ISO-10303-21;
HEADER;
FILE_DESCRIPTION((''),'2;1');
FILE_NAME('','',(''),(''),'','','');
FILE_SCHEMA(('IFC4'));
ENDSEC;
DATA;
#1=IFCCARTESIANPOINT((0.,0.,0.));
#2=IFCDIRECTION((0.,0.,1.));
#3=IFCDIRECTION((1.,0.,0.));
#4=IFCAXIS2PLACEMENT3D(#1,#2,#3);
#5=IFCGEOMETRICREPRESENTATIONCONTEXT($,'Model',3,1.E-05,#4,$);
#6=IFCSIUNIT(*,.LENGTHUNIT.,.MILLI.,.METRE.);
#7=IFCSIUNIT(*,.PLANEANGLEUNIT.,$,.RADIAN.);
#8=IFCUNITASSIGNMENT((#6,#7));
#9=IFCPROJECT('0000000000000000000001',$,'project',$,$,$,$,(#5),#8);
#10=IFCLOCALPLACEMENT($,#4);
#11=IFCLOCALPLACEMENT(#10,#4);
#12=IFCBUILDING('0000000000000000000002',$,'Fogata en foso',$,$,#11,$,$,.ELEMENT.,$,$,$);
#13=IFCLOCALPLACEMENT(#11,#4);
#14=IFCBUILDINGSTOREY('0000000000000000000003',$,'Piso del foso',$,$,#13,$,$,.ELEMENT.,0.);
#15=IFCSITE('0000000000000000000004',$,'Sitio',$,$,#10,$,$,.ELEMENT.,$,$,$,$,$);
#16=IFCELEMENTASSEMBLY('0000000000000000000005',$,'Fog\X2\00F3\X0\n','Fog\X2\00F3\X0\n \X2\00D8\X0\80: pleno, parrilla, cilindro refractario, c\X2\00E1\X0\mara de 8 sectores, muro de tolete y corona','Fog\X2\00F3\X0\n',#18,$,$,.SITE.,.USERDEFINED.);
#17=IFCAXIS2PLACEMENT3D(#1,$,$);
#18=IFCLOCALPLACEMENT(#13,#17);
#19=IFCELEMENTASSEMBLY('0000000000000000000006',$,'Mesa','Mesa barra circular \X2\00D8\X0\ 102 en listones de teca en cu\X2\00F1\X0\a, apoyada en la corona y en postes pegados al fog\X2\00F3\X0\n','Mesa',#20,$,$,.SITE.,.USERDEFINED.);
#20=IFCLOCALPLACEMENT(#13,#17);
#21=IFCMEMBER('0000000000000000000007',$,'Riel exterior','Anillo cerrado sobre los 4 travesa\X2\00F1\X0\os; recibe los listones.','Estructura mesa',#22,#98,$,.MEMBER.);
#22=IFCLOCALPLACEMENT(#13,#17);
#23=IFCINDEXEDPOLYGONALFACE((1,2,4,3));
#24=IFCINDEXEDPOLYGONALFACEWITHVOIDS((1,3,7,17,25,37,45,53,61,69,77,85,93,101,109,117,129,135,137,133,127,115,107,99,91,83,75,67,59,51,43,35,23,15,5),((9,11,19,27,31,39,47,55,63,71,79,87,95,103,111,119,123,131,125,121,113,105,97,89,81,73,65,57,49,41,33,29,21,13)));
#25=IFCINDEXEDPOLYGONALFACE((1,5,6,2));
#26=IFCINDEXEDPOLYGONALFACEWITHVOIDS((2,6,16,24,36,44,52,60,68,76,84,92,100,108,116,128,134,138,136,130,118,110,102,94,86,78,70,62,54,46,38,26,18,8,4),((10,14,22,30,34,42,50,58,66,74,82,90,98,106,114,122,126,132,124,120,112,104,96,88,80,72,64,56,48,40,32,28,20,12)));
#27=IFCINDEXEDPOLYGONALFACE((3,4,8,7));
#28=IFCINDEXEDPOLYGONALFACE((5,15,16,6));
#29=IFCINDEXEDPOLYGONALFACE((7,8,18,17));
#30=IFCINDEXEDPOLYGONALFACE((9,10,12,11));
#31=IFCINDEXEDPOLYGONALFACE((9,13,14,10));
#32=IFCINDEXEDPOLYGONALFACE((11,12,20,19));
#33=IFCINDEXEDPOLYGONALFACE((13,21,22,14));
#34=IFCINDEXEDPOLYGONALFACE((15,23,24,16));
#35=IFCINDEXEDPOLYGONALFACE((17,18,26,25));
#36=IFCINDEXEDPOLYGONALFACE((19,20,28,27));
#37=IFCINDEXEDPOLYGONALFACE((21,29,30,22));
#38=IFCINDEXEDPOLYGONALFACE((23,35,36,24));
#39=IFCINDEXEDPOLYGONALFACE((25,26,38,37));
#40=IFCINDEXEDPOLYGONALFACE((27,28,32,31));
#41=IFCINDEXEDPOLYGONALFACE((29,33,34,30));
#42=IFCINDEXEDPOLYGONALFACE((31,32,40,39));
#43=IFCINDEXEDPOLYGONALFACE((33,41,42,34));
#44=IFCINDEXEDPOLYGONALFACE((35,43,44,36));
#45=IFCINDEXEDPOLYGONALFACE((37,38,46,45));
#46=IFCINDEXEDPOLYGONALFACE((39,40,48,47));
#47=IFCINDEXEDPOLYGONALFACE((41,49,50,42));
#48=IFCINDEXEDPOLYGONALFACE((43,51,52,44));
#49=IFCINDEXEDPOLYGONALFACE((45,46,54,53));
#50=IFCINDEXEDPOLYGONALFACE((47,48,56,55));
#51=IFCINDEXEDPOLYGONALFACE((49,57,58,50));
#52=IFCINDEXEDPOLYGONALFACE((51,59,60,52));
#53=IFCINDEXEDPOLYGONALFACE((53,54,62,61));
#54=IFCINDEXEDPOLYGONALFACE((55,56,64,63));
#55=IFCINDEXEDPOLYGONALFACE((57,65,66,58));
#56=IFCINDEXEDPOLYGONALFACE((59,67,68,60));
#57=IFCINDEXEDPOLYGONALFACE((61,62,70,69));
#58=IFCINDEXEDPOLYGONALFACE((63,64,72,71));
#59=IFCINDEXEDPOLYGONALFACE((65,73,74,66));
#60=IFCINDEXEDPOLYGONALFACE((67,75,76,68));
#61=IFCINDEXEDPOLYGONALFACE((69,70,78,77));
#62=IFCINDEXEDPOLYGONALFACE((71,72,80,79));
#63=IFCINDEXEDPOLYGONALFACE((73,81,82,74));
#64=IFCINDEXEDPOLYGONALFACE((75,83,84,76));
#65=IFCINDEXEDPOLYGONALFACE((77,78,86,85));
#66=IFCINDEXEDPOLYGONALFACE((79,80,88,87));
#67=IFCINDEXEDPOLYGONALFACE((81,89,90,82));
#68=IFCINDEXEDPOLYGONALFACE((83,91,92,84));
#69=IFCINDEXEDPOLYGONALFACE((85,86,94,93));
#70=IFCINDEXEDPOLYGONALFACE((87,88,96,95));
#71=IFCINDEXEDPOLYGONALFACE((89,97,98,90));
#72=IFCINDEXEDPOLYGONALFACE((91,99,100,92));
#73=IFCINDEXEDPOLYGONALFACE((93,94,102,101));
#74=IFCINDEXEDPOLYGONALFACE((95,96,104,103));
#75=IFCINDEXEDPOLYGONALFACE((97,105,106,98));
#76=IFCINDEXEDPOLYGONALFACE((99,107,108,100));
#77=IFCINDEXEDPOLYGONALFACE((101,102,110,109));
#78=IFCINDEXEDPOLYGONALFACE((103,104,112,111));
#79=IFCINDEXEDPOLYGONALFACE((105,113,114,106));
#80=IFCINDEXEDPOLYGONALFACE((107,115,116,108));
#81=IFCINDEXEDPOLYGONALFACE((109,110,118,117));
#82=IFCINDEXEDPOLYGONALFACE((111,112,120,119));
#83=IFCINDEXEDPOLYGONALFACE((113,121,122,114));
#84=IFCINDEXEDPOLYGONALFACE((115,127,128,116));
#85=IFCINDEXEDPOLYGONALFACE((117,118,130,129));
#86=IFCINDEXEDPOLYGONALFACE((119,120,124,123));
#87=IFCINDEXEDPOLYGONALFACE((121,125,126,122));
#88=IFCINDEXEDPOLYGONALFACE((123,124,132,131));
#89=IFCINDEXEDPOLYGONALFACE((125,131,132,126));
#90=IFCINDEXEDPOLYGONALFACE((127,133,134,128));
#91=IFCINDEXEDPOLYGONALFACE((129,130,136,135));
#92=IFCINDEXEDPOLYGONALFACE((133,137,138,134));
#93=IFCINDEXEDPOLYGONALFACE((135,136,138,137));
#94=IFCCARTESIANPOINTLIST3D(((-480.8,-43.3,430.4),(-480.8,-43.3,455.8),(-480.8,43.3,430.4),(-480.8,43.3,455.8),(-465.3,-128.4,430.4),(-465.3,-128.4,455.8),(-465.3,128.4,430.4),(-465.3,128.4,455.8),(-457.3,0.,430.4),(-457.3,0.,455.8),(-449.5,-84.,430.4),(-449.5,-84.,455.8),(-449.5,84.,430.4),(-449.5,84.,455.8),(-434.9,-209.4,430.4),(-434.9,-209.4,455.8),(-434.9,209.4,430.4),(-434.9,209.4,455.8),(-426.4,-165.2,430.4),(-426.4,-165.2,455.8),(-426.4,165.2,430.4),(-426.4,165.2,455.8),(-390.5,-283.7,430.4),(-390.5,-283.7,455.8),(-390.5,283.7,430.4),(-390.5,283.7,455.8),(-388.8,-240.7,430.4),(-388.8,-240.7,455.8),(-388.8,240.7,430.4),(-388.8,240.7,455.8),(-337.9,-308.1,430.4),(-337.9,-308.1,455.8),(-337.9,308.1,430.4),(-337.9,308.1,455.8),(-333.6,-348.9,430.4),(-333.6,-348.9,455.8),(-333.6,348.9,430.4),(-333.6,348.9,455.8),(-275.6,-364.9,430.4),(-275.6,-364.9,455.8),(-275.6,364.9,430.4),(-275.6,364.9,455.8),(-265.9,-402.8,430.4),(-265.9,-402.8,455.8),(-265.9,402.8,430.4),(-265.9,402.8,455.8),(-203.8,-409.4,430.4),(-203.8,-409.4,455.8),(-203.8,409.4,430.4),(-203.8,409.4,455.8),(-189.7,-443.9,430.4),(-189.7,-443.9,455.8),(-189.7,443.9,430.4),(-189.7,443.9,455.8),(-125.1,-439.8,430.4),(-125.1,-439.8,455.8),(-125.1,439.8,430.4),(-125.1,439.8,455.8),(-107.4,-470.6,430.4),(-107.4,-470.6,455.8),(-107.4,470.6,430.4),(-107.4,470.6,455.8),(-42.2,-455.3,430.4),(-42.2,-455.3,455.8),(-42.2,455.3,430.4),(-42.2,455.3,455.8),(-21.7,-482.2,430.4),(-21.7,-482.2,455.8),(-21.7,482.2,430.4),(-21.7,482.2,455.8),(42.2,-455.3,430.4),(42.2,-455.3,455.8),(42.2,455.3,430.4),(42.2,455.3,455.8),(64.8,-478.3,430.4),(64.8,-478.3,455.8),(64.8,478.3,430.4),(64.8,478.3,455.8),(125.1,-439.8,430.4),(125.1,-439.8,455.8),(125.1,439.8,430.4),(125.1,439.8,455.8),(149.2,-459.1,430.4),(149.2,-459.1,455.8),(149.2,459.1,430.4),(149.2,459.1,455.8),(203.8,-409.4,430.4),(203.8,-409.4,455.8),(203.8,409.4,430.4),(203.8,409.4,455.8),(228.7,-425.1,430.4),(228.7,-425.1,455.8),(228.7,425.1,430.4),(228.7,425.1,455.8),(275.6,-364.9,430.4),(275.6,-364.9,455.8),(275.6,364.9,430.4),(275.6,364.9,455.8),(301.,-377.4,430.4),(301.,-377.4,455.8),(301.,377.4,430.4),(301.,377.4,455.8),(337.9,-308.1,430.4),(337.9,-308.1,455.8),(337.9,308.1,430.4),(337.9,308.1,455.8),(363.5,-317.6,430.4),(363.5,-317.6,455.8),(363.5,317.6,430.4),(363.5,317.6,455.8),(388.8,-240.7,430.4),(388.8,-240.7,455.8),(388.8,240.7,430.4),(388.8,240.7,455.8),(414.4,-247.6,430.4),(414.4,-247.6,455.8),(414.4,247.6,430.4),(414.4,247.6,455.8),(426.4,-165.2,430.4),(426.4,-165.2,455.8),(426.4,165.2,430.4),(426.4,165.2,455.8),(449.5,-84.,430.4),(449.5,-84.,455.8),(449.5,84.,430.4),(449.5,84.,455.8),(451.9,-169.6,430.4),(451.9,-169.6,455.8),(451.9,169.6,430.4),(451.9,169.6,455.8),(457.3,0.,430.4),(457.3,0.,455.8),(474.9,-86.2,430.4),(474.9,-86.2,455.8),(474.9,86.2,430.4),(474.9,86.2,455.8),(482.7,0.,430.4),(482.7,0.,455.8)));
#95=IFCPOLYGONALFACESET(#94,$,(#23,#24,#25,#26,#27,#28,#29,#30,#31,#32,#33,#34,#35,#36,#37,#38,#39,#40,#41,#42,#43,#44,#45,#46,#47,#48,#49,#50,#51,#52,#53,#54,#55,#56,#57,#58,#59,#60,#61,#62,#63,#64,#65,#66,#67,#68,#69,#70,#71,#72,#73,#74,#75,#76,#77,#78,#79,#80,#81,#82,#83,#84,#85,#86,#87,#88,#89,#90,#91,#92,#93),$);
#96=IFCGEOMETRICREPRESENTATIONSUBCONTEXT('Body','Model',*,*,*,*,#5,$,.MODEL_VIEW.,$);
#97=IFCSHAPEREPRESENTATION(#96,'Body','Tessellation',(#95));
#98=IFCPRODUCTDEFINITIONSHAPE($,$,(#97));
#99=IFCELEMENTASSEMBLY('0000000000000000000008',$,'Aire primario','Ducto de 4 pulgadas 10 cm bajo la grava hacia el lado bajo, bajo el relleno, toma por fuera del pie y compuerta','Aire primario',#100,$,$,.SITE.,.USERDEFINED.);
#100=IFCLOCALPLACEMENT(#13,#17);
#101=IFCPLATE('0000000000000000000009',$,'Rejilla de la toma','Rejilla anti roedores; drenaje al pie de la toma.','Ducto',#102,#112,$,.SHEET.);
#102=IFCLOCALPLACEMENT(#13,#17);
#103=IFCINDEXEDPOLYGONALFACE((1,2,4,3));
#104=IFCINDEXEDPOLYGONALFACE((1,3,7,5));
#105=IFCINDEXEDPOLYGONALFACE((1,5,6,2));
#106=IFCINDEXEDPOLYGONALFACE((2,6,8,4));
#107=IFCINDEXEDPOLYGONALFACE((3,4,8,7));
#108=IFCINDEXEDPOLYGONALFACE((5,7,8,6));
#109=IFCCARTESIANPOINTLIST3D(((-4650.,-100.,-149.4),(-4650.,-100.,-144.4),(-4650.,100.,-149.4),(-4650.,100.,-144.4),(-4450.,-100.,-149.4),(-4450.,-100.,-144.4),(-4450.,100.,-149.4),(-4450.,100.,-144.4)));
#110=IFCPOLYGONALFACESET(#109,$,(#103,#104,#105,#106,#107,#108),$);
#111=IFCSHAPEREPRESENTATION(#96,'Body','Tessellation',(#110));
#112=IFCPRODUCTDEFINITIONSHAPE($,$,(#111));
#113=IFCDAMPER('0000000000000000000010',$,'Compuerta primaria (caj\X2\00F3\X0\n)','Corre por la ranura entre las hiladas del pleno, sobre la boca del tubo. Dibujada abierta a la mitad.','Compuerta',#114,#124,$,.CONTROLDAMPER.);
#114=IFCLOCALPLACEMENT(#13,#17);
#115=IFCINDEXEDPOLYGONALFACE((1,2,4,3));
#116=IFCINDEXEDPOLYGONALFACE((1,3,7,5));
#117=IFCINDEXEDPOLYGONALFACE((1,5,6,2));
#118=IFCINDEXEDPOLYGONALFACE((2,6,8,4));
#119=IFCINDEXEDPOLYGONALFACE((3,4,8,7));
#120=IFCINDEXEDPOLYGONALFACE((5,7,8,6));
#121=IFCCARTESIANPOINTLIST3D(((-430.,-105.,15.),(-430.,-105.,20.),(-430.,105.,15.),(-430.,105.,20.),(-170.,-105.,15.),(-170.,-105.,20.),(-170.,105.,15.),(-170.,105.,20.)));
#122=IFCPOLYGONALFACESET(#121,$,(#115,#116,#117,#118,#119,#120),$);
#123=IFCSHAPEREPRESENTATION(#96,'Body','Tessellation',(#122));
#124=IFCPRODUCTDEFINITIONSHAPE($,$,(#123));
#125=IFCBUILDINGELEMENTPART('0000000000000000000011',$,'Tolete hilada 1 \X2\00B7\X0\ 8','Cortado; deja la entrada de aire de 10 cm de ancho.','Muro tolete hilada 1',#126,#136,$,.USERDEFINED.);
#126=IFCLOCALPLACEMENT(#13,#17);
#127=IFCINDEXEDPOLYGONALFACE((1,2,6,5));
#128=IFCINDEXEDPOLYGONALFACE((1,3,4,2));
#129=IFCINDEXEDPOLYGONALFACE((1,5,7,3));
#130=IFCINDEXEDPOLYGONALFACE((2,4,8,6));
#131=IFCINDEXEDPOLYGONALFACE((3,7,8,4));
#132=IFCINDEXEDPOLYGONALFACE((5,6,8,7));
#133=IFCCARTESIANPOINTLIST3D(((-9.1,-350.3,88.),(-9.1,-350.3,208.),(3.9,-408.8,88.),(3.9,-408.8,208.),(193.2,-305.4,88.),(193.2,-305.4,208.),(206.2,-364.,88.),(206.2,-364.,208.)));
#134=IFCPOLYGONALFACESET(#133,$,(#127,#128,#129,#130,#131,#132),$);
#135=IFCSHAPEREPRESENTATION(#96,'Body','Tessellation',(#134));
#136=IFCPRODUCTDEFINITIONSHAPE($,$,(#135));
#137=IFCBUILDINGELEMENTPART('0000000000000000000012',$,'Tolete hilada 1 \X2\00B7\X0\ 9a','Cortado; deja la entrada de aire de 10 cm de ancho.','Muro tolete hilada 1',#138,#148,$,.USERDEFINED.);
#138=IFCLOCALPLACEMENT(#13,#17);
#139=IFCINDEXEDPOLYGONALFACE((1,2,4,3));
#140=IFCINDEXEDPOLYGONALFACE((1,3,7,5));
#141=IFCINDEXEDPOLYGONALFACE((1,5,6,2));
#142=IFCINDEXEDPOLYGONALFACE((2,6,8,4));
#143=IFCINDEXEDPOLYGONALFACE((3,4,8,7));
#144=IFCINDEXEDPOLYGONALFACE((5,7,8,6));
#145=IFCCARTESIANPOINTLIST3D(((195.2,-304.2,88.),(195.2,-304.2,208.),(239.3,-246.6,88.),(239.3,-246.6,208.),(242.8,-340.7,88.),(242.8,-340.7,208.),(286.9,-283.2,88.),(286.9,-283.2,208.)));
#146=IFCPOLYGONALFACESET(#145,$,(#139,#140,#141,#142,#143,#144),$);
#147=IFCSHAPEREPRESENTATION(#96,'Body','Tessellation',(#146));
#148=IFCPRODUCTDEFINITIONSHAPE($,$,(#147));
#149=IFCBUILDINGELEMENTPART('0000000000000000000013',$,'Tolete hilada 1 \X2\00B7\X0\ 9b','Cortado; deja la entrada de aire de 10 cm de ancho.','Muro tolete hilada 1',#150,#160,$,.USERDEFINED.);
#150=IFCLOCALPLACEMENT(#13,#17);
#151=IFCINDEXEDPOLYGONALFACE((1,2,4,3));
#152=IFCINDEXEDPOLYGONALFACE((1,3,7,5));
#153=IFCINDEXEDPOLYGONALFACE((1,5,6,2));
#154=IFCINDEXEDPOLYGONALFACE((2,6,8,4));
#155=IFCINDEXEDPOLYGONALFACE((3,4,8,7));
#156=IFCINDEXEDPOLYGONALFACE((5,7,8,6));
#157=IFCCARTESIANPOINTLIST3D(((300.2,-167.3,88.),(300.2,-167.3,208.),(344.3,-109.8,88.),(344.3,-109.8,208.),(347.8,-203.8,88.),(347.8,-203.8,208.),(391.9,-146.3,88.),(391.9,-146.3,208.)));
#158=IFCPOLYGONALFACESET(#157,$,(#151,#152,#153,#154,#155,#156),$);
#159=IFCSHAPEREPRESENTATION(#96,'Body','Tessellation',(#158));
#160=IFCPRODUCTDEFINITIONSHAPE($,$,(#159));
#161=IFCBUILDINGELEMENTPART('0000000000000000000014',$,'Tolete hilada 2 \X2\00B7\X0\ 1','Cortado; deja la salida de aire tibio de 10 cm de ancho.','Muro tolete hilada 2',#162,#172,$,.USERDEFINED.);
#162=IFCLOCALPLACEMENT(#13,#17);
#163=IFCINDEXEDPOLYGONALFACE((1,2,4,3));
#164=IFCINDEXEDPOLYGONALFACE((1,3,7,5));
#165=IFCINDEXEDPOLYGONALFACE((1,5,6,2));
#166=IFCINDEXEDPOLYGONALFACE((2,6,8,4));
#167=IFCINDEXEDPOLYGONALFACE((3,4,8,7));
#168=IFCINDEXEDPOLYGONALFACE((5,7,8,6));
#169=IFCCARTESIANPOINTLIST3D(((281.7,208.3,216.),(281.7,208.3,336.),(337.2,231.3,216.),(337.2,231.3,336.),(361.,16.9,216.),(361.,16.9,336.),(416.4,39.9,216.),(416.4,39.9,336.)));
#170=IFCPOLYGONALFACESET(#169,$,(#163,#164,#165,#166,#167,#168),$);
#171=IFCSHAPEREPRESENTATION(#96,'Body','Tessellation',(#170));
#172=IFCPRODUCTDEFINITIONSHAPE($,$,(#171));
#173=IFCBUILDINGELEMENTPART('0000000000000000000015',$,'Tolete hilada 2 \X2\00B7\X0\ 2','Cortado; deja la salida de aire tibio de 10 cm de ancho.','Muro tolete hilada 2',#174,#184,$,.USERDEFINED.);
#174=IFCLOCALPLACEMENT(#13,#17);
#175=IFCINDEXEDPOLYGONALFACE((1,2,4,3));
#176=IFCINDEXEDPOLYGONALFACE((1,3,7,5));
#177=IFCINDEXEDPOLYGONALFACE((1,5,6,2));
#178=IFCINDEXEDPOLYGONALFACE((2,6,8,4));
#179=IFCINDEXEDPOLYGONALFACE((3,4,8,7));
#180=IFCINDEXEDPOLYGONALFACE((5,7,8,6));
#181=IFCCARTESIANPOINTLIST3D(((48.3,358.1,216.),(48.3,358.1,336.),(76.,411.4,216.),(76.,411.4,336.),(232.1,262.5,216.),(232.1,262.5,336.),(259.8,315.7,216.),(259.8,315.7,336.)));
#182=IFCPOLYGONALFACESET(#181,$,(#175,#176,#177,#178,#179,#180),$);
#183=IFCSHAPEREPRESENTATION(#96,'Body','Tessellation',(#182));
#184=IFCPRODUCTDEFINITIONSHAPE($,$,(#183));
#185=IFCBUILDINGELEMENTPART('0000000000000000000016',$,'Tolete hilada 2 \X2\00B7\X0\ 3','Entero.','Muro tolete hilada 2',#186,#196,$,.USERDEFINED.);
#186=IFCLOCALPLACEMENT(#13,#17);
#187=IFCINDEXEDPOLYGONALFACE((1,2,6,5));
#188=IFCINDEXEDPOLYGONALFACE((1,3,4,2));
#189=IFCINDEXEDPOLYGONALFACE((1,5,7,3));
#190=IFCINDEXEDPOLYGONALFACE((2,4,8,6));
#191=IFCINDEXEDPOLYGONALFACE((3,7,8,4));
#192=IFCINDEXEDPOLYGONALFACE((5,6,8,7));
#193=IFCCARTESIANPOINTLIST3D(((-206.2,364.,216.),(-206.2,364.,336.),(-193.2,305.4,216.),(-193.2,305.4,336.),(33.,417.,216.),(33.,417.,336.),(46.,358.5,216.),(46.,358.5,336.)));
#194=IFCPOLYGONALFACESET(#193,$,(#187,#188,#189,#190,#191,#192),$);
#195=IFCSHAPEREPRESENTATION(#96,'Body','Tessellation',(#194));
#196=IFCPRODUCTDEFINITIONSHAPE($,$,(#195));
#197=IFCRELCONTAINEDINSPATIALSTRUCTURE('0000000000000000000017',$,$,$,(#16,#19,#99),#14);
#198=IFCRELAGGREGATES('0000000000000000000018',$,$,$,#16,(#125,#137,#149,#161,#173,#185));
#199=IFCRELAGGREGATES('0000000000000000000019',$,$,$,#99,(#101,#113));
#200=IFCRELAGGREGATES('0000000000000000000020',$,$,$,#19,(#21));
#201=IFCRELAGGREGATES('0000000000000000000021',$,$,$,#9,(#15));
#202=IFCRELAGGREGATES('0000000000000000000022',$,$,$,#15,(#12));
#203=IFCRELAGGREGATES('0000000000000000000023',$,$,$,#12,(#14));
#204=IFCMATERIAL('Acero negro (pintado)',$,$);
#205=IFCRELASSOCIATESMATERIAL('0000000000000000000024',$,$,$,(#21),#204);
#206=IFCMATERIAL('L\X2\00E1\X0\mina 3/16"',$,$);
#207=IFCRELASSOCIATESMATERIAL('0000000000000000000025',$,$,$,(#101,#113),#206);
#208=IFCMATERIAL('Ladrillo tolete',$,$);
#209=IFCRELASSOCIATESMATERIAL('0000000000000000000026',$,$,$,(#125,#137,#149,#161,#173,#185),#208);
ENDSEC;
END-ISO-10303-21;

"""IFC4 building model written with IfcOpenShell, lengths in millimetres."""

from ifc_helpers import new_model, si_unit, frame, origin_with_axes, origin_2d, place, context, subcontext, project, spatial, polyline, hollow_circle, outline, extrude, material, element, aggregate, save


model = new_model("IFC4")

# Units and contexts
model_context = context("Model", 3, precision=1e-05, world=origin_with_axes())
body_context = subcontext(model_context, "Body", "Model", "MODEL_VIEW")
ifc_project = project(units=[si_unit("LENGTHUNIT", "METRE", prefix="MILLI"), si_unit("PLANEANGLEUNIT", "RADIAN")], contexts=[model_context])

# Site, building, storey
site_placement = place(None, origin_with_axes())
site = spatial("IfcSite", under=ifc_project, at=site_placement, Name="Sitio", CompositionType="ELEMENT")
building_placement = place(site_placement, origin_with_axes())
building = spatial("IfcBuilding", under=site, at=building_placement, Name="Fogata en foso", CompositionType="ELEMENT")
storey_placement = place(building_placement, origin_with_axes())
storey = spatial("IfcBuildingStorey", under=building, at=storey_placement, Name="Piso del foso", CompositionType="ELEMENT", Elevation=0.0)

# Element assembly
assembly_1_placement = place(storey_placement, origin_with_axes())
assembly_1 = element("IfcElementAssembly", 1, at=assembly_1_placement, inside=storey, Name="Fogón", Description="Fogón Ø80: pleno, parrilla, cilindro refractario, cámara de 8 sectores, muro de tolete y corona", ObjectType="Fogón", AssemblyPlace="SITE", PredefinedType="USERDEFINED")

# Element assembly, member
assembly_2_placement = place(storey_placement, origin_with_axes())
assembly_2 = element("IfcElementAssembly", 2, at=assembly_2_placement, inside=storey, Name="Mesa", Description="Mesa barra circular Ø 102 en listones de teca en cuña, apoyada en la corona y en postes pegados al fogón", ObjectType="Mesa", AssemblyPlace="SITE", PredefinedType="USERDEFINED")
ifc_material_1 = material(Name="Acero negro (pintado)")
member_1_placement = place(storey_placement, frame((0.0, 0.0, 430.4), z_axis=(0.0, 0.0, 1.0), x_axis=(1.0, 0.0, 0.0)))
member_1 = element("IfcMember", 3, at=member_1_placement, material=ifc_material_1, Name="Riel exterior", Description="Anillo cerrado sobre los 4 travesaños; recibe los listones.", ObjectType="Estructura mesa", PredefinedType="MEMBER", context=body_context, shape_type="SweptSolid", body=[
    extrude(hollow_circle(Radius=482.7, WallThickness=25.4, at=origin_2d()), origin_with_axes(), (0.0, 0.0, 1.0), 25.4),
])

# Element assembly, plate, damper
assembly_3_placement = place(storey_placement, origin_with_axes())
assembly_3 = element("IfcElementAssembly", 4, at=assembly_3_placement, inside=storey, Name="Aire primario", Description="Ducto de 4 pulgadas 10 cm bajo la grava hacia el lado bajo, bajo el relleno, toma por fuera del pie y compuerta", ObjectType="Aire primario", AssemblyPlace="SITE", PredefinedType="USERDEFINED")
ifc_material_2 = material(Name="Lámina 3/16\"")
plate_placement = place(storey_placement, frame((0.0, 0.0, -149.4), z_axis=(0.0, 0.0, 1.0), x_axis=(1.0, 0.0, 0.0)))
plate = element("IfcPlate", 5, at=plate_placement, material=ifc_material_2, Name="Rejilla de la toma", Description="Rejilla anti roedores; drenaje al pie de la toma.", ObjectType="Ducto", PredefinedType="SHEET", context=body_context, shape_type="SweptSolid", body=[
    extrude(outline(polyline([(-4650.0, -100.0), (-4450.0, -100.0), (-4450.0, 100.0), (-4650.0, 100.0), (-4650.0, -100.0)])), origin_with_axes(), (0.0, 0.0, 1.0), 5.0),
])
damper_placement = place(storey_placement, frame((0.0, 0.0, 15.0), z_axis=(0.0, 0.0, 1.0), x_axis=(1.0, 0.0, 0.0)))
damper = element("IfcDamper", 6, at=damper_placement, material=ifc_material_2, Name="Compuerta primaria (cajón)", Description="Corre por la ranura entre las hiladas del pleno, sobre la boca del tubo. Dibujada abierta a la mitad.", ObjectType="Compuerta", PredefinedType="CONTROLDAMPER", context=body_context, shape_type="SweptSolid", body=[
    extrude(outline(polyline([(-430.0, -105.0), (-170.0, -105.0), (-170.0, 105.0), (-430.0, 105.0), (-430.0, -105.0)])), origin_with_axes(), (0.0, 0.0, 1.0), 5.0),
])

# Building element parts
ifc_material_3 = material(Name="Ladrillo tolete")
building_element_part_1_placement = place(storey_placement, frame((0.0, 0.0, 88.0), z_axis=(0.0, 0.0, 1.0), x_axis=(1.0, 0.0, 0.0)))
building_element_part_1 = element("IfcBuildingElementPart", 7, at=building_element_part_1_placement, material=ifc_material_3, Name="Tolete hilada 1 · 8", Description="Cortado; deja la entrada de aire de 10 cm de ancho.", ObjectType="Muro tolete hilada 1", PredefinedType="USERDEFINED", context=body_context, shape_type="SweptSolid", body=[
    extrude(outline(polyline([(3.9, -408.8), (206.2, -364.0), (193.2, -305.4), (-9.1, -350.3), (3.9, -408.8)])), origin_with_axes(), (0.0, 0.0, 1.0), 120.0),
])
building_element_part_2_placement = place(storey_placement, frame((0.0, 0.0, 88.0), z_axis=(0.0, 0.0, 1.0), x_axis=(1.0, 0.0, 0.0)))
building_element_part_2 = element("IfcBuildingElementPart", 8, at=building_element_part_2_placement, material=ifc_material_3, Name="Tolete hilada 1 · 9a", Description="Cortado; deja la entrada de aire de 10 cm de ancho.", ObjectType="Muro tolete hilada 1", PredefinedType="USERDEFINED", context=body_context, shape_type="SweptSolid", body=[
    extrude(outline(polyline([(242.8, -340.7), (286.9, -283.2), (239.3, -246.6), (195.2, -304.2), (242.8, -340.7)])), origin_with_axes(), (0.0, 0.0, 1.0), 120.0),
])
building_element_part_3_placement = place(storey_placement, frame((0.0, 0.0, 88.0), z_axis=(0.0, 0.0, 1.0), x_axis=(1.0, 0.0, 0.0)))
building_element_part_3 = element("IfcBuildingElementPart", 9, at=building_element_part_3_placement, material=ifc_material_3, Name="Tolete hilada 1 · 9b", Description="Cortado; deja la entrada de aire de 10 cm de ancho.", ObjectType="Muro tolete hilada 1", PredefinedType="USERDEFINED", context=body_context, shape_type="SweptSolid", body=[
    extrude(outline(polyline([(347.8, -203.8), (391.9, -146.3), (344.3, -109.8), (300.2, -167.3), (347.8, -203.8)])), origin_with_axes(), (0.0, 0.0, 1.0), 120.0),
])
building_element_part_4_placement = place(storey_placement, frame((0.0, 0.0, 216.0), z_axis=(0.0, 0.0, 1.0), x_axis=(1.0, 0.0, 0.0)))
building_element_part_4 = element("IfcBuildingElementPart", 10, at=building_element_part_4_placement, material=ifc_material_3, Name="Tolete hilada 2 · 1", Description="Cortado; deja la salida de aire tibio de 10 cm de ancho.", ObjectType="Muro tolete hilada 2", PredefinedType="USERDEFINED", context=body_context, shape_type="SweptSolid", body=[
    extrude(outline(polyline([(416.4, 39.9), (337.1, 231.3), (281.7, 208.3), (361.0, 16.9), (416.4, 39.9)])), origin_with_axes(), (0.0, 0.0, 1.0), 120.0),
])
building_element_part_5_placement = place(storey_placement, frame((0.0, 0.0, 216.0), z_axis=(0.0, 0.0, 1.0), x_axis=(1.0, 0.0, 0.0)))
building_element_part_5 = element("IfcBuildingElementPart", 11, at=building_element_part_5_placement, material=ifc_material_3, Name="Tolete hilada 2 · 2", Description="Cortado; deja la salida de aire tibio de 10 cm de ancho.", ObjectType="Muro tolete hilada 2", PredefinedType="USERDEFINED", context=body_context, shape_type="SweptSolid", body=[
    extrude(outline(polyline([(259.8, 315.7), (76.0, 411.4), (48.3, 358.1), (232.1, 262.5), (259.8, 315.7)])), origin_with_axes(), (0.0, 0.0, 1.0), 120.0),
])
building_element_part_6_placement = place(storey_placement, frame((0.0, 0.0, 216.0), z_axis=(0.0, 0.0, 1.0), x_axis=(1.0, 0.0, 0.0)))
building_element_part_6 = element("IfcBuildingElementPart", 12, at=building_element_part_6_placement, material=ifc_material_3, Name="Tolete hilada 2 · 3", Description="Entero.", ObjectType="Muro tolete hilada 2", PredefinedType="USERDEFINED", context=body_context, shape_type="SweptSolid", body=[
    extrude(outline(polyline([(33.0, 417.0), (-206.2, 364.0), (-193.2, 305.4), (46.0, 358.5), (33.0, 417.0)])), origin_with_axes(), (0.0, 0.0, 1.0), 120.0),
])
aggregate(assembly_1, [building_element_part_1, building_element_part_2, building_element_part_3, building_element_part_4, building_element_part_5, building_element_part_6])
aggregate(assembly_3, [plate, damper])

aggregate(assembly_2, [member_1])

save(model, "model.ifc")
